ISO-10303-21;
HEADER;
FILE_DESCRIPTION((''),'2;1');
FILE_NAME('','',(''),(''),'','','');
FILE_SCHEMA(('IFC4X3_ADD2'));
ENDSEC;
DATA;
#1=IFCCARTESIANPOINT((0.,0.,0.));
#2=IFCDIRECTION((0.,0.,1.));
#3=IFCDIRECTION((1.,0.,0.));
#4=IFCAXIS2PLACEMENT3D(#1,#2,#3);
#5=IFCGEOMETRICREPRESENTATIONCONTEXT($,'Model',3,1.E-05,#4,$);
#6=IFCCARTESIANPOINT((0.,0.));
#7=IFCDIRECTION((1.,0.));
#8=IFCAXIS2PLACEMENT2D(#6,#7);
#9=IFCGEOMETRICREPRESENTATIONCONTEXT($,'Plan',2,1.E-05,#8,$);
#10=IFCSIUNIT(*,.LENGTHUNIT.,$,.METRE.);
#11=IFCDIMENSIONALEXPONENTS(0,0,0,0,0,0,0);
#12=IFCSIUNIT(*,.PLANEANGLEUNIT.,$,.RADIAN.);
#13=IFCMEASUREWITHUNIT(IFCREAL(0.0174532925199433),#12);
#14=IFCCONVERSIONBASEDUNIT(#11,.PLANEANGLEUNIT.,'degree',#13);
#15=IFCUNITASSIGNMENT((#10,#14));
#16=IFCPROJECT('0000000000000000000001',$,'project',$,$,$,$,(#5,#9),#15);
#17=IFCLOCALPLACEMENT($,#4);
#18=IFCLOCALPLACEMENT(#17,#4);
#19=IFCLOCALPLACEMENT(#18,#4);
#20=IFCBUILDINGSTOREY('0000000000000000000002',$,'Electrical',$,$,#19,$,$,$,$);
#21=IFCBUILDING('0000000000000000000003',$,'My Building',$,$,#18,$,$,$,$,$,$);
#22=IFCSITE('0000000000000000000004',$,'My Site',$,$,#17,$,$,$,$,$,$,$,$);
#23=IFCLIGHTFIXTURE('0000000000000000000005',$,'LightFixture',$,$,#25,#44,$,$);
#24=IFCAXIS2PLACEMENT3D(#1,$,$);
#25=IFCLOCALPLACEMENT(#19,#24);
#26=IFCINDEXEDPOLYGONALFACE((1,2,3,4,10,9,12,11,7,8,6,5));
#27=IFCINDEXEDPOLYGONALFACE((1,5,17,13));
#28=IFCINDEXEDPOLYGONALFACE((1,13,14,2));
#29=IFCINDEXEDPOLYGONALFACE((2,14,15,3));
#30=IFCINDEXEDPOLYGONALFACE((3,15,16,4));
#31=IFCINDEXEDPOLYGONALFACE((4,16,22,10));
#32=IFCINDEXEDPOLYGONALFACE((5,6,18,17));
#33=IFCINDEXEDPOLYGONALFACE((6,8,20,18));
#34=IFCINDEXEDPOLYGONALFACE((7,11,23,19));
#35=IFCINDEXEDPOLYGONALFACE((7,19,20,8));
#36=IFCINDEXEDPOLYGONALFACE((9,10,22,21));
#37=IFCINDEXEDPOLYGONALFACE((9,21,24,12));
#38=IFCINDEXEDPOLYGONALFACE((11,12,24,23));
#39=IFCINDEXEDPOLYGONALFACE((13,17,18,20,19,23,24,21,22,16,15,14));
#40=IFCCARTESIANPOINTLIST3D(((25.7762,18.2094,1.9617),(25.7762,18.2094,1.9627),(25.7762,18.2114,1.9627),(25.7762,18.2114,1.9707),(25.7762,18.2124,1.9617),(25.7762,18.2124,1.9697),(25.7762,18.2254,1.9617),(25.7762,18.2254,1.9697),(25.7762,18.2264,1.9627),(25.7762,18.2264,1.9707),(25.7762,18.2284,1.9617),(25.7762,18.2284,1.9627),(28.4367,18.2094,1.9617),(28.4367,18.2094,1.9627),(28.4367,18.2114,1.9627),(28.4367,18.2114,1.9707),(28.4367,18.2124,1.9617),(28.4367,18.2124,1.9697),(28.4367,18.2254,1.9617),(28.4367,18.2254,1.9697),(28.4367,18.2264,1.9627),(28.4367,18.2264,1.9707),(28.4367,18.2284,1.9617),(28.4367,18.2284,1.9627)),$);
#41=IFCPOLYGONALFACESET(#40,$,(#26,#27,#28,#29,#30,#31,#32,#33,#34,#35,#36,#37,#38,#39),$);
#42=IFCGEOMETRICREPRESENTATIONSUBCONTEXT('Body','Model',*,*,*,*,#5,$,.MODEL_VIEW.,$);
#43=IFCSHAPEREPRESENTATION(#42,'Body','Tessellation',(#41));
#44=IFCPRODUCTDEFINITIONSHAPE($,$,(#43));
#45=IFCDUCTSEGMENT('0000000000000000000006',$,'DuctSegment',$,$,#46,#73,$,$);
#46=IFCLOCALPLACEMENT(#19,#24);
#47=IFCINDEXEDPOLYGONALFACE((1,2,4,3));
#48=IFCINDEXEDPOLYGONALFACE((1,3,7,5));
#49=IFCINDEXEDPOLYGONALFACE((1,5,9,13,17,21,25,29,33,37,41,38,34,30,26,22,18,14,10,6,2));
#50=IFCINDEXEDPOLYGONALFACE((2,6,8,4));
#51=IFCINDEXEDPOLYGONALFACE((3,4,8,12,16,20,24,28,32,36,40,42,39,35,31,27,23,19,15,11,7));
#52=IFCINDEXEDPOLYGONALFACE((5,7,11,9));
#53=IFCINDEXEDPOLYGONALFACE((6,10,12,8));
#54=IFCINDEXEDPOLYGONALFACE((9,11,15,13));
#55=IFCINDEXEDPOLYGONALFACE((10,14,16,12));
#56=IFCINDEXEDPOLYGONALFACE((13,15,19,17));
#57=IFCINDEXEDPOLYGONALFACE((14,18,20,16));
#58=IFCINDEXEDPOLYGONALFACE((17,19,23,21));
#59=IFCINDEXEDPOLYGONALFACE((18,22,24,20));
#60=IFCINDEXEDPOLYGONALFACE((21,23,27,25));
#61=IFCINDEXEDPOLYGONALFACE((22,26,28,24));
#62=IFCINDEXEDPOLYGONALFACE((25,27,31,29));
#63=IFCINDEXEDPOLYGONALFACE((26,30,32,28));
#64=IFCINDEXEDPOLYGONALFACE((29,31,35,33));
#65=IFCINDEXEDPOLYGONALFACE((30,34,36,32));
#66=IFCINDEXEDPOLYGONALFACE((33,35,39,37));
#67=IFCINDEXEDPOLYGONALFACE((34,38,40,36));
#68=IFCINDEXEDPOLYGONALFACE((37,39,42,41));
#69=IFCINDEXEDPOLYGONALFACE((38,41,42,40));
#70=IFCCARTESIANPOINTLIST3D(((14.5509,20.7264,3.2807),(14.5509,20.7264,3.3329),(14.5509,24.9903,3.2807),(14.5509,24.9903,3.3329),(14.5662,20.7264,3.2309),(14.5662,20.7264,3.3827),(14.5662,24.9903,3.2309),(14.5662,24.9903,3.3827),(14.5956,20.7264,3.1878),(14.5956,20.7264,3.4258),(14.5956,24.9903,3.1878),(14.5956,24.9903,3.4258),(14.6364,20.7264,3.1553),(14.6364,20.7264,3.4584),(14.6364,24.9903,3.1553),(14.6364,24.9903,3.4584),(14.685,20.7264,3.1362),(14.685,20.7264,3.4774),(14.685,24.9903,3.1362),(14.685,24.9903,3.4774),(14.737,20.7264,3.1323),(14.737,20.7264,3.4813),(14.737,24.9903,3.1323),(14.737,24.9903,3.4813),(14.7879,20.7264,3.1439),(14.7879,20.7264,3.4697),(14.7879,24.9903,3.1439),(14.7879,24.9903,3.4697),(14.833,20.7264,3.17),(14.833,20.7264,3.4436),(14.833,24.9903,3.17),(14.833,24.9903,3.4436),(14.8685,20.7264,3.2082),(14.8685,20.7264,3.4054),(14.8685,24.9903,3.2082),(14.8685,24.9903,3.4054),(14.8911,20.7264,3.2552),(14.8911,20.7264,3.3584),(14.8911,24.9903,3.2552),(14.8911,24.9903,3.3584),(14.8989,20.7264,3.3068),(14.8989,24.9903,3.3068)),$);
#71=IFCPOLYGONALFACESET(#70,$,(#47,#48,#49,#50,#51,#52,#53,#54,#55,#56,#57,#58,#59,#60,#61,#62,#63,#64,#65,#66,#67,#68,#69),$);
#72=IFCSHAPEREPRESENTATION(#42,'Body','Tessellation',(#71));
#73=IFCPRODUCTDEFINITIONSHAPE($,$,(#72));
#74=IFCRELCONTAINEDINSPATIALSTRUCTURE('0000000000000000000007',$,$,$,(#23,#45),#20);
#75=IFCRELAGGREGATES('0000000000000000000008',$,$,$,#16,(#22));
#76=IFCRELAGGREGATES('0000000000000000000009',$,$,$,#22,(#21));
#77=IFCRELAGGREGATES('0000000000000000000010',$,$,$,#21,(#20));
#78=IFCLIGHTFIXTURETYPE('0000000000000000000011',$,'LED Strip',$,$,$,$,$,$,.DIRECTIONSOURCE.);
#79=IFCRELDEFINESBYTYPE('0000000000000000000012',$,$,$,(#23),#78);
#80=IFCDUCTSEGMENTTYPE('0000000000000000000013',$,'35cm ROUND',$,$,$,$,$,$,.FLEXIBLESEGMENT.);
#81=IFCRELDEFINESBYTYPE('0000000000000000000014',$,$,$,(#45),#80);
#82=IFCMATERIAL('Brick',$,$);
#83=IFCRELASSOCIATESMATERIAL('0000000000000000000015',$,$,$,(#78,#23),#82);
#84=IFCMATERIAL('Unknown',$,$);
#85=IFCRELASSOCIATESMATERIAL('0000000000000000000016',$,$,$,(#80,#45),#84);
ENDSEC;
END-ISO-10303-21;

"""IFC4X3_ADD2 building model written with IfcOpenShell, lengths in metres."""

from ifc_helpers import new_model, entity, si_unit, converted_unit, frame, origin_with_axes, origin_2d_with_axis, place, context, subcontext, project, spatial, indexed_curve, circle, outline, extrude, material, material_profile, profile_set, profile_usage, type_object, element, save


model = new_model("IFC4X3_ADD2")

# Units and contexts
model_context = context("Model", 3, precision=1e-05, world=origin_with_axes())
plan_context = context("Plan", 2, precision=1e-05, world=origin_2d_with_axis())
body_context = subcontext(model_context, "Body", "Model", "MODEL_VIEW")
ifc_project = project(units=[si_unit("LENGTHUNIT", "METRE"), converted_unit("PLANEANGLEUNIT", "degree", entity("IfcReal", 0.0174532925199433), si_unit("PLANEANGLEUNIT", "RADIAN"), dimensions=[0, 0, 0, 0, 0, 0, 0])], contexts=[model_context, plan_context])

# Site, building, storey
site_placement = place(None, origin_with_axes())
site = spatial("IfcSite", under=ifc_project, at=site_placement, Name="My Site")
building_placement = place(site_placement, origin_with_axes())
building = spatial("IfcBuilding", under=site, at=building_placement, Name="My Building")
storey_placement = place(building_placement, origin_with_axes())
storey = spatial("IfcBuildingStorey", under=building, at=storey_placement, Name="Electrical")

# Shared definitions
ifc_material_1 = material(Name="Brick")

# Light fixture
ifc_material_profile_1 = material_profile(ifc_material_1, outline(indexed_curve([(0.003, 0.0), (0.003, 0.008), (0.016, 0.008), (0.016, 0.0), (0.019, 0.0), (0.019, 0.001), (0.017, 0.001), (0.017, 0.009), (0.002, 0.009), (0.002, 0.001), (0.0, 0.001), (0.0, 0.0), (0.003, 0.0)])))
ifc_profile_set_1 = profile_set([ifc_material_profile_1])
light_fixture_type = type_object("IfcLightFixtureType", Name="LED Strip", PredefinedType="DIRECTIONSOURCE", material=ifc_profile_set_1)
ifc_profile_usage_1 = profile_usage(ifc_profile_set_1, cardinal=5)
light_fixture_1_placement = place(storey_placement, frame((25.7762, 18.2094, 1.9617), z_axis=(1.0, 0.0, 0.0), x_axis=(0.0, 1.0, 0.0)))
element("IfcLightFixture", 1, at=light_fixture_1_placement, inside=storey, type_object=light_fixture_type, material=ifc_profile_usage_1, Name="LightFixture", context=body_context, shape_type="SweptSolid", body=[
    extrude(outline(indexed_curve([(0.003, 0.0), (0.003, 0.008), (0.016, 0.008), (0.016, 0.0), (0.019, 0.0), (0.019, 0.001), (0.017, 0.001), (0.017, 0.009), (0.002, 0.009), (0.002, 0.001), (0.0, 0.001), (0.0, 0.0), (0.003, 0.0)])), origin_with_axes(), (0.0, 0.0, 1.0), 2.6605),
])

# Duct segment
ifc_material_2 = material(Name="Unknown")
ifc_material_profile_2 = material_profile(ifc_material_2, circle(Radius=0.175))
ifc_profile_set_2 = profile_set([ifc_material_profile_2])
ifc_profile_usage_2 = profile_usage(ifc_profile_set_2, cardinal=5)
duct_segment_type = type_object("IfcDuctSegmentType", Name="35cm ROUND", PredefinedType="FLEXIBLESEGMENT", material=ifc_profile_set_2)
duct_segment_placement = place(storey_placement, frame((14.7239, 24.9903, 3.3068), z_axis=(0.0, -1.0, 0.0), x_axis=(1.0, 0.0, 0.0)))
element("IfcDuctSegment", 2, at=duct_segment_placement, inside=storey, type_object=duct_segment_type, material=ifc_profile_usage_2, Name="DuctSegment", context=body_context, shape_type="SweptSolid", body=[
    extrude(circle(Radius=0.175), origin_with_axes(), (0.0, 0.0, 1.0), 4.2639),
])

save(model, "model.ifc")
